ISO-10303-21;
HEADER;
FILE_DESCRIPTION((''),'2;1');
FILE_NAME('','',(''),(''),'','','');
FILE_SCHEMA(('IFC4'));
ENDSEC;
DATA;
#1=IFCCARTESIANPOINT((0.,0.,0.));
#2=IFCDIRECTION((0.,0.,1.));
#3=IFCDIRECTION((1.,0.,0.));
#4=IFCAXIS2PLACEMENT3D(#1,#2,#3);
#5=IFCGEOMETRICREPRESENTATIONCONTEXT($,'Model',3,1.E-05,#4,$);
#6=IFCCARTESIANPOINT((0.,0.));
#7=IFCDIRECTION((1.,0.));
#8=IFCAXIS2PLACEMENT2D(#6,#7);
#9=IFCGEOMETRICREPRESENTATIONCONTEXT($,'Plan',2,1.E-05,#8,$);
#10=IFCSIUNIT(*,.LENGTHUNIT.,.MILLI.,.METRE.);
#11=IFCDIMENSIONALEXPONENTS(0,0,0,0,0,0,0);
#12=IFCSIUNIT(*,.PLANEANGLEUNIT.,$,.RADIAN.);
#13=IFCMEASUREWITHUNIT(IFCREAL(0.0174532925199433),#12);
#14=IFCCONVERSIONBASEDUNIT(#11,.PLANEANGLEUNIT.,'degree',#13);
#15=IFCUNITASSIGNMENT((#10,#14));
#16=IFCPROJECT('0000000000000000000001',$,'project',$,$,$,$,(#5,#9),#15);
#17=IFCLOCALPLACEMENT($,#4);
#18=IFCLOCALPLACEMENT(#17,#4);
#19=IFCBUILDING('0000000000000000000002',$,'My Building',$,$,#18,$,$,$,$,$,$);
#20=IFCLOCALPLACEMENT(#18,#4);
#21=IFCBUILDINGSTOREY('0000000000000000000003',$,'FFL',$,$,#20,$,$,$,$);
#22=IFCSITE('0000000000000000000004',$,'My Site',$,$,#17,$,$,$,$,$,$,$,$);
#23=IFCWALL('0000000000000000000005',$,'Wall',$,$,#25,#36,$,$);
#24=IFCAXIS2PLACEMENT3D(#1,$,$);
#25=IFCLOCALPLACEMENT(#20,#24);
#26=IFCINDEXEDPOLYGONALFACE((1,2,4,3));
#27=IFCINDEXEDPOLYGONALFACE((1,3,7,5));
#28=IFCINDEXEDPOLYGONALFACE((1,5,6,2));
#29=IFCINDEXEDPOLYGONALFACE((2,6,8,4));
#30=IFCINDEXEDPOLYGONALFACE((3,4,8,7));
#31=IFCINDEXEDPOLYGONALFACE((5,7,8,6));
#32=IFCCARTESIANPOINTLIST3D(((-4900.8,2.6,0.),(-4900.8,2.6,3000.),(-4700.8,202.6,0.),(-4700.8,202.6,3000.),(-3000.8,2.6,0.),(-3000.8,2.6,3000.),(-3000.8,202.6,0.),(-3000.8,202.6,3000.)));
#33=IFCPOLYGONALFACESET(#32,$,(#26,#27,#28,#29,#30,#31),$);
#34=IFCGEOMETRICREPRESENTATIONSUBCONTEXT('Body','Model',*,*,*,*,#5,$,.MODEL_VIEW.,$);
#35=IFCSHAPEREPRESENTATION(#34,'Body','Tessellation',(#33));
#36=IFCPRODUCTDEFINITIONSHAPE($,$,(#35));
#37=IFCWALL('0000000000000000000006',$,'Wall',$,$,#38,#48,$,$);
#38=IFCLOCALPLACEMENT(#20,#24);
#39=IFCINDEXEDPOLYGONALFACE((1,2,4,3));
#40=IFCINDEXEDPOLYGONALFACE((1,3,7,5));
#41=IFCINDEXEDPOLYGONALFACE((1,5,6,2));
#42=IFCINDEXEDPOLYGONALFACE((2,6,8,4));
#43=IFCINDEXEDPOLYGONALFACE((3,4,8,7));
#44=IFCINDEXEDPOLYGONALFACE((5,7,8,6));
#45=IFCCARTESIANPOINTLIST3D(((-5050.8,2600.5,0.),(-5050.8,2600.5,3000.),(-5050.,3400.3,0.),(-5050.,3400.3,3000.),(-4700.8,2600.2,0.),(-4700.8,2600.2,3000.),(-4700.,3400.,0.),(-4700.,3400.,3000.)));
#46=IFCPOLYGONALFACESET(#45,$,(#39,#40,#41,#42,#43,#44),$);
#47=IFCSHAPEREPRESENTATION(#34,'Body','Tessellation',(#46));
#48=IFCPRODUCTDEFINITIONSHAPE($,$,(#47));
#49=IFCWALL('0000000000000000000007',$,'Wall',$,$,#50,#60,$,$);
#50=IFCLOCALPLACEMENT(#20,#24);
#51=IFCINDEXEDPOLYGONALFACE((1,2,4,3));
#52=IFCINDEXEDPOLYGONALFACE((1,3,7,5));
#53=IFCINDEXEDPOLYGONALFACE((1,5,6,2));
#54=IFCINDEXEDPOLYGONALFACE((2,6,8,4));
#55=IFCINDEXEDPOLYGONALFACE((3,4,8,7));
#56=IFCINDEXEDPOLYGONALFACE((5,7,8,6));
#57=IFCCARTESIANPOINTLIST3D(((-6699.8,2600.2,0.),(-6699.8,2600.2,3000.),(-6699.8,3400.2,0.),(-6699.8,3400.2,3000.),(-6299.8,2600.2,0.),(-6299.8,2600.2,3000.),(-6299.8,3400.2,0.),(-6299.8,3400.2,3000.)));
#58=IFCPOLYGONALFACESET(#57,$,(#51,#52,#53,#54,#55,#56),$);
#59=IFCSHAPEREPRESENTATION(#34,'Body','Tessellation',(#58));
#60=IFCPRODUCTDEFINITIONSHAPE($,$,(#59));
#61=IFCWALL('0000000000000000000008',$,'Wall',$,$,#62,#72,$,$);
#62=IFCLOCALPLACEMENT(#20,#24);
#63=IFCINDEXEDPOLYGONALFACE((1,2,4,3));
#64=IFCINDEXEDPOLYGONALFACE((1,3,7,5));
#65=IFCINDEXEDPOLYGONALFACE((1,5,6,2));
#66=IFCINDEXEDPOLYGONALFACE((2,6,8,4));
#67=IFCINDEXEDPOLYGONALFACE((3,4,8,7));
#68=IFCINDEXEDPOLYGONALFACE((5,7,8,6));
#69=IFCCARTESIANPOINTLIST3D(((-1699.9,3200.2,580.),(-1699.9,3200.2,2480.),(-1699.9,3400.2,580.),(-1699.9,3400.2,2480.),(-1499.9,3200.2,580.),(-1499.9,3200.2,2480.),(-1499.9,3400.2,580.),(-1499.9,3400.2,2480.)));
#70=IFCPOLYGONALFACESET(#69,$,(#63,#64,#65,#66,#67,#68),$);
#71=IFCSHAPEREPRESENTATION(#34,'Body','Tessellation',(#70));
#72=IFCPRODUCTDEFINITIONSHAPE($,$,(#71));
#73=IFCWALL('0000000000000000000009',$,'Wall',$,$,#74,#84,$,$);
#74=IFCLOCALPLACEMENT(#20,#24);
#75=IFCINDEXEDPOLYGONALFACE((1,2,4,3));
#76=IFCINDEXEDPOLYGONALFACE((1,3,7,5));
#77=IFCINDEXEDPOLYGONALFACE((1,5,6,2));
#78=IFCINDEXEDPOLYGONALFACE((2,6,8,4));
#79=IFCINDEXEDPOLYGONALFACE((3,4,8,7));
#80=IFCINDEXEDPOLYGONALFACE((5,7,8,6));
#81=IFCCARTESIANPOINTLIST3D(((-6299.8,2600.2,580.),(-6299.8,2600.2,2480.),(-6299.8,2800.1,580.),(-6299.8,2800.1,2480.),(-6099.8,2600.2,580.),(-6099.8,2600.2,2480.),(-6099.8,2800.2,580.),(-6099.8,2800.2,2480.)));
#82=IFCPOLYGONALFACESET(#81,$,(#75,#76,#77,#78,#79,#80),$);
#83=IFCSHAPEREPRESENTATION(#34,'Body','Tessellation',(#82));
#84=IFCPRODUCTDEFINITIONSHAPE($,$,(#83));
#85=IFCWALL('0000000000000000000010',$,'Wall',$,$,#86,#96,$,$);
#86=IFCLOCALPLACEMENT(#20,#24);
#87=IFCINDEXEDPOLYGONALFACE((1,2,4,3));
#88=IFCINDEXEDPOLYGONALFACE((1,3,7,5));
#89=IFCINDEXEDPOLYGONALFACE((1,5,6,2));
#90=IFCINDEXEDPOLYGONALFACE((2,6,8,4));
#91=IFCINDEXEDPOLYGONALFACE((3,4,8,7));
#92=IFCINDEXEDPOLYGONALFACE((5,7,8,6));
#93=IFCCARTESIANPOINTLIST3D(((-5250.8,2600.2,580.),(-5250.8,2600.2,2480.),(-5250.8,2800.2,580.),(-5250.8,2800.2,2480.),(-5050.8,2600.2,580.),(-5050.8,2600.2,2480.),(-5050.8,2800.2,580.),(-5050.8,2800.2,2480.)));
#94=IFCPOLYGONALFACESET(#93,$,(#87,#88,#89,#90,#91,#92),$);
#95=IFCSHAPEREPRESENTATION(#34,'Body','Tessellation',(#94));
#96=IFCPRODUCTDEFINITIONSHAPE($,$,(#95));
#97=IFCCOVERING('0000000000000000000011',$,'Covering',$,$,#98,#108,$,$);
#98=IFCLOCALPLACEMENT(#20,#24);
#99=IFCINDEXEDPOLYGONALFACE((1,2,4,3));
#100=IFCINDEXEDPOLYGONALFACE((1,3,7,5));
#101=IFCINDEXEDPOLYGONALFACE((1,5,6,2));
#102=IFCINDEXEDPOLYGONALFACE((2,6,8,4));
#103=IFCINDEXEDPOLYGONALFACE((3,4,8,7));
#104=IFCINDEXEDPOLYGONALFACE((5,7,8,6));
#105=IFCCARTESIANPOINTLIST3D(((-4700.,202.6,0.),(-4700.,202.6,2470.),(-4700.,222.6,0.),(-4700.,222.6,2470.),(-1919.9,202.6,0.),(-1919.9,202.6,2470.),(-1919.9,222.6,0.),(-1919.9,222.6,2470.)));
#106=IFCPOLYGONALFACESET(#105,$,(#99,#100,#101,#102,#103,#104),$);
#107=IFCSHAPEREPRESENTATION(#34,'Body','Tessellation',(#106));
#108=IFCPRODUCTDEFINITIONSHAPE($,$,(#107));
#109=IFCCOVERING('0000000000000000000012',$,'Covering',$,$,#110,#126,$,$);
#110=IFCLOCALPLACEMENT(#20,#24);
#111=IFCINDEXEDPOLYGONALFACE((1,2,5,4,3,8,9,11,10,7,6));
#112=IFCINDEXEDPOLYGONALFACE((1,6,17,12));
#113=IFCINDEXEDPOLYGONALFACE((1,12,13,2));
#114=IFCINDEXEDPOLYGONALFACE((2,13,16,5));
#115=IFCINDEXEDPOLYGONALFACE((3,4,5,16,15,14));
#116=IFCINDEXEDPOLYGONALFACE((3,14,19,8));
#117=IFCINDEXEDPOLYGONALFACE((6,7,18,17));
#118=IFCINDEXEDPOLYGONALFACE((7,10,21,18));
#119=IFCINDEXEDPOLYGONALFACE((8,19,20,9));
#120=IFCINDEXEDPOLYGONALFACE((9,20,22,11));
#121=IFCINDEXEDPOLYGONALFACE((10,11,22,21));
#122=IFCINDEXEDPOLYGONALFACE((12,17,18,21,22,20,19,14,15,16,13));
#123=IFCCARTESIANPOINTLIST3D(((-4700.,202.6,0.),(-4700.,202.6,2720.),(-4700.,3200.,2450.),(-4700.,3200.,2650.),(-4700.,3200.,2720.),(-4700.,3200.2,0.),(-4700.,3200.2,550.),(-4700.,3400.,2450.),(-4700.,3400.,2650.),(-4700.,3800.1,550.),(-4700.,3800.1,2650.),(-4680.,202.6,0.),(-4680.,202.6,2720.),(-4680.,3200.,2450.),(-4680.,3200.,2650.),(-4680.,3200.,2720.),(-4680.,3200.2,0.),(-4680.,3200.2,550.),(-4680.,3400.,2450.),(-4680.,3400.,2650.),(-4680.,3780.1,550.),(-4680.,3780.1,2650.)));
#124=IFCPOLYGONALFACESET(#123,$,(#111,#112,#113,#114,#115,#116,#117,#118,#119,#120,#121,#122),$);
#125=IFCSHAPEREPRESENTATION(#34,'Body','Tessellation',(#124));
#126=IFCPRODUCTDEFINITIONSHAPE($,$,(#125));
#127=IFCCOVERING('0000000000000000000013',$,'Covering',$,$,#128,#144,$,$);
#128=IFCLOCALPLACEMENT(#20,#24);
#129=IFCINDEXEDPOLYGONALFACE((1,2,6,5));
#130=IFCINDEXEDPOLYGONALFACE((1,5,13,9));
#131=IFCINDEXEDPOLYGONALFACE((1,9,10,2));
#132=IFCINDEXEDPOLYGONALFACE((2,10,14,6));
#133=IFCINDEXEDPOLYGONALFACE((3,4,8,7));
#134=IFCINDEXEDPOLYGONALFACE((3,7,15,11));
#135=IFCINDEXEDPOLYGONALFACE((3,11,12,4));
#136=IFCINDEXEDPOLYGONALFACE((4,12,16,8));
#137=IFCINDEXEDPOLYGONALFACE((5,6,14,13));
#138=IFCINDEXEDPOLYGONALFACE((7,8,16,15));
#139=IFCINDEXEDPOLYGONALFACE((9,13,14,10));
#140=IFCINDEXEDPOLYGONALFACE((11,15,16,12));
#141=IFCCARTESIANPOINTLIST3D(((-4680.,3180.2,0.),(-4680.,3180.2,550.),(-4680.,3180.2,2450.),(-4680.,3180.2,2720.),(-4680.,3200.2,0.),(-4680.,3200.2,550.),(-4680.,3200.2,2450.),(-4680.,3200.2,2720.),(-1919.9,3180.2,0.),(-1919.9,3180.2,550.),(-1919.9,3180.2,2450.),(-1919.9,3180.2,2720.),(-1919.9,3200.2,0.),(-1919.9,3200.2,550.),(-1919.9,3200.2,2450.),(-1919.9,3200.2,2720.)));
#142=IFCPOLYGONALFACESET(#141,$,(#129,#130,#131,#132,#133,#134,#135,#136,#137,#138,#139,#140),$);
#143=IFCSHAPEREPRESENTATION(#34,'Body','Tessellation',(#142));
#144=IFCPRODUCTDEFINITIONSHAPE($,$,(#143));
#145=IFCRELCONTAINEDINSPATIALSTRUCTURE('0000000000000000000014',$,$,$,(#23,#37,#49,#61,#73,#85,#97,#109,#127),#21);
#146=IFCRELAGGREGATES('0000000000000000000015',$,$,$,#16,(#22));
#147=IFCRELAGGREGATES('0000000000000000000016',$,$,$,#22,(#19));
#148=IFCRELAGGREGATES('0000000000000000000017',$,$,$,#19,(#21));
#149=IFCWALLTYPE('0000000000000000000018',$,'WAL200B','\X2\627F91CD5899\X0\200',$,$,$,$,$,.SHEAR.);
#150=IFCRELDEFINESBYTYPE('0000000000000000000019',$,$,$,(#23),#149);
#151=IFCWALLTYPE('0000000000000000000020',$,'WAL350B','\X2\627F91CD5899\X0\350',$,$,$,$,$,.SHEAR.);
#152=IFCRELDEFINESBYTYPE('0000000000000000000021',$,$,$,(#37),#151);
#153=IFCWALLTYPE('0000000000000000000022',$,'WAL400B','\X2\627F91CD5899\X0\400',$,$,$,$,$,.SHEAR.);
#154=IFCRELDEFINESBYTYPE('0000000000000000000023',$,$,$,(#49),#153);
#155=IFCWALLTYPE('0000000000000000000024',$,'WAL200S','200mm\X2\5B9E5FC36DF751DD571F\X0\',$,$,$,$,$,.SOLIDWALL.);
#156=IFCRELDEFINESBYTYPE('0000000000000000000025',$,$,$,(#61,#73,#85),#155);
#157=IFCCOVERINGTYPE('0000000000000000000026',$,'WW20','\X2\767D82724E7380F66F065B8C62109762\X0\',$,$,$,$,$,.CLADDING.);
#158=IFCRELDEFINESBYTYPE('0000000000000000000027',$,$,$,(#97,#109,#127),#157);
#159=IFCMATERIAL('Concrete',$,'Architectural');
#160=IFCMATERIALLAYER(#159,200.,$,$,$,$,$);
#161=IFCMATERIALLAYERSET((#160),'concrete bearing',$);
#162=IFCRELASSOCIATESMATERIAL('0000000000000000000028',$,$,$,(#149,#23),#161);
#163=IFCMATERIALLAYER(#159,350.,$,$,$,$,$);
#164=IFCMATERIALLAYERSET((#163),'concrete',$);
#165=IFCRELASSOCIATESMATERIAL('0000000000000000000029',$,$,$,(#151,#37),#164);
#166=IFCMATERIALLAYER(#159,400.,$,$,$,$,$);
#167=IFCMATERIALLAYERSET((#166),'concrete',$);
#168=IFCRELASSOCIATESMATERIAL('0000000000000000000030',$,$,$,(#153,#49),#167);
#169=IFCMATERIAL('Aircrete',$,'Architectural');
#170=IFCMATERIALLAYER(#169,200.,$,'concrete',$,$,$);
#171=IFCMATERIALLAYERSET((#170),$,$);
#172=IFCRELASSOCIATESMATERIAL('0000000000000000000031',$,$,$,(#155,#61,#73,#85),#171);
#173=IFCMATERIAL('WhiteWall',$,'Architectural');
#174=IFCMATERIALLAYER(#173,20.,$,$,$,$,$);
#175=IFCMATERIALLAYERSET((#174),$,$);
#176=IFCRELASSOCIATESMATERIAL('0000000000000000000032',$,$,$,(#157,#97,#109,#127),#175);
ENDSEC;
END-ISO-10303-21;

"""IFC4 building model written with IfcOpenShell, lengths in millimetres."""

from ifc_helpers import new_model, entity, si_unit, converted_unit, frame, origin_with_axes, origin_2d_with_axis, place, context, subcontext, project, spatial, line, indexed_curve, outline, extrude, material, layer, layer_set, layer_usage, type_object, element, save


model = new_model("IFC4")

# Units and contexts
model_context = context("Model", 3, precision=1e-05, world=origin_with_axes())
plan_context = context("Plan", 2, precision=1e-05, world=origin_2d_with_axis())
body_context_1 = subcontext(model_context, "Body", "Model", "MODEL_VIEW")
ifc_project = project(units=[si_unit("LENGTHUNIT", "METRE", prefix="MILLI"), converted_unit("PLANEANGLEUNIT", "degree", entity("IfcReal", 0.0174532925199433), si_unit("PLANEANGLEUNIT", "RADIAN"), dimensions=[0, 0, 0, 0, 0, 0, 0])], contexts=[model_context, plan_context])

# Site, building, storey
site_placement = place(None, origin_with_axes())
site = spatial("IfcSite", under=ifc_project, at=site_placement, Name="My Site")
building_placement = place(site_placement, origin_with_axes())
building = spatial("IfcBuilding", under=site, at=building_placement, Name="My Building")
storey_placement = place(building_placement, origin_with_axes())
storey = spatial("IfcBuildingStorey", under=building, at=storey_placement, Name="FFL")

# Shared definitions
ifc_material_1 = material(Name="Aircrete", Category="Architectural")

# Walls
ifc_material_2 = material(Name="Concrete", Category="Architectural")
ifc_layer_1 = layer(ifc_material_2, 200.0)
ifc_layer_set_1 = layer_set([ifc_layer_1], Name="concrete bearing")
wall_type_1 = type_object("IfcWallType", Name="WAL200B", Description="承重墙200", PredefinedType="SHEAR", material=ifc_layer_set_1)
ifc_layer_usage_1 = layer_usage(ifc_layer_set_1, "AXIS2", "NEGATIVE", 0.0)
wall_1_placement = place(storey_placement, frame((-4700.8, 202.6, 0.0), z_axis=(0.0, 0.0, 1.0), x_axis=(1.0, 0.000001, 0.0)))
element("IfcWall", 1, at=wall_1_placement, inside=storey, type_object=wall_type_1, material=ifc_layer_usage_1, Name="Wall", context=body_context_1, shape_type="SweptSolid", body=[
    extrude(outline(indexed_curve([(-200.0, -200.0), (0.0, 0.0), (1700.0, 0.0), (1700.0, -200.0)], segments=[line(1, 2, 3, 4, 1)])), origin_with_axes(), (0.0, 0.0, 1.0), 3000.0),
])
ifc_layer_2 = layer(ifc_material_2, 350.0)
ifc_layer_set_2 = layer_set([ifc_layer_2], Name="concrete")
ifc_layer_usage_2 = layer_usage(ifc_layer_set_2, "AXIS2", "POSITIVE", 0.0)
wall_type_2 = type_object("IfcWallType", Name="WAL350B", Description="承重墙350", PredefinedType="SHEAR", material=ifc_layer_set_2)
wall_2_placement = place(storey_placement, frame((-4700.8, 2600.2, 0.0), z_axis=(0.0, 0.0, 1.0), x_axis=(0.000938, 1.0, 0.0)))
element("IfcWall", 2, at=wall_2_placement, inside=storey, type_object=wall_type_2, material=ifc_layer_usage_2, Name="Wall", context=body_context_1, shape_type="SweptSolid", body=[
    extrude(outline(indexed_curve([(0.0, 0.0), (0.0, 350.0), (799.8, 350.0), (799.8, 0.0)], segments=[line(1, 2, 3, 4, 1)])), origin_with_axes(), (0.0, 0.0, 1.0), 3000.0),
])
ifc_layer_3 = layer(ifc_material_2, 400.0)
ifc_layer_set_3 = layer_set([ifc_layer_3], Name="concrete")
ifc_layer_usage_3 = layer_usage(ifc_layer_set_3, "AXIS2", "POSITIVE", 0.0)
wall_type_3 = type_object("IfcWallType", Name="WAL400B", Description="承重墙400", PredefinedType="SHEAR", material=ifc_layer_set_3)
wall_3_placement = place(storey_placement, frame((-6699.8, 3400.2, 0.0), z_axis=(0.0, 0.0, 1.0), x_axis=(0.0, -1.0, 0.0)))
element("IfcWall", 3, at=wall_3_placement, inside=storey, type_object=wall_type_3, material=ifc_layer_usage_3, Name="Wall", context=body_context_1, shape_type="SweptSolid", body=[
    extrude(outline(indexed_curve([(0.0, 0.0), (0.0, 400.0), (800.0, 400.0), (800.0, 0.0)], segments=[line(1, 2, 3, 4, 1)])), origin_with_axes(), (0.0, 0.0, 1.0), 3000.0),
])
ifc_layer_4 = layer(ifc_material_1, 200.0, Name="concrete")
ifc_layer_set_4 = layer_set([ifc_layer_4])
ifc_layer_usage_4 = layer_usage(ifc_layer_set_4, "AXIS2", "NEGATIVE", 0.0)
wall_type_4 = type_object("IfcWallType", Name="WAL200S", Description="200mm实心混凝土", PredefinedType="SOLIDWALL", material=ifc_layer_set_4)
wall_4_placement = place(storey_placement, frame((-1699.9, 3200.2, 580.0), z_axis=(0.0, 0.0, 1.0), x_axis=(-0.000002, 1.0, 0.0)))
element("IfcWall", 4, at=wall_4_placement, inside=storey, type_object=wall_type_4, material=ifc_layer_usage_4, Name="Wall", context=body_context_1, shape_type="SweptSolid", body=[
    extrude(outline(indexed_curve([(0.0, -200.0), (0.0, 0.0), (200.0, 0.0), (200.0, -200.0)], segments=[line(1, 2, 3, 4, 1)])), origin_with_axes(), (0.0, 0.0, 1.0), 1900.0),
])
ifc_layer_usage_5 = layer_usage(ifc_layer_set_4, "AXIS2", "NEGATIVE", 0.0)
wall_5_placement = place(storey_placement, frame((-6299.8, 2600.2, 580.0), z_axis=(0.0, 0.0, 1.0), x_axis=(-0.000002, 1.0, 0.0)))
element("IfcWall", 5, at=wall_5_placement, inside=storey, type_object=wall_type_4, material=ifc_layer_usage_5, Name="Wall", context=body_context_1, shape_type="SweptSolid", body=[
    extrude(outline(indexed_curve([(0.0, -200.0), (0.0, 0.0), (200.0, 0.0), (200.0, -200.0)], segments=[line(1, 2, 3, 4, 1)])), origin_with_axes(), (0.0, 0.0, 1.0), 1900.0),
])
ifc_layer_usage_6 = layer_usage(ifc_layer_set_4, "AXIS2", "NEGATIVE", 0.0)
wall_6_placement = place(storey_placement, frame((-5050.8, 2800.2, 580.0), z_axis=(0.0, 0.0, 1.0), x_axis=(0.000002, -1.0, 0.0)))
element("IfcWall", 6, at=wall_6_placement, inside=storey, type_object=wall_type_4, material=ifc_layer_usage_6, Name="Wall", context=body_context_1, shape_type="SweptSolid", body=[
    extrude(outline(indexed_curve([(0.0, -200.0), (0.0, 0.0), (200.0, 0.0), (200.0, -200.0)], segments=[line(1, 2, 3, 4, 1)])), origin_with_axes(), (0.0, 0.0, 1.0), 1900.0),
])

# Covering
ifc_material_3 = material(Name="WhiteWall", Category="Architectural")
ifc_layer_5 = layer(ifc_material_3, 20.0)
ifc_layer_set_5 = layer_set([ifc_layer_5])
ifc_layer_usage_7 = layer_usage(ifc_layer_set_5, "AXIS2", "POSITIVE", 0.0)
covering_type = type_object("IfcCoveringType", Name="WW20", Description="白色乳胶漆完成面", PredefinedType="CLADDING", material=ifc_layer_set_5)
covering_1_placement = place(storey_placement, frame((-4700.0, 202.6, 0.0), z_axis=(0.0, 0.0, 1.0), x_axis=(1.0, -0.000001, 0.0)))
element("IfcCovering", 7, at=covering_1_placement, inside=storey, type_object=covering_type, material=ifc_layer_usage_7, Name="Covering", context=body_context_1, shape_type="SweptSolid", body=[
    extrude(outline(indexed_curve([(0.0, 0.0), (0.0, 20.0), (2780.1, 20.0), (2780.1, 0.0)], segments=[line(1, 2, 3, 4, 1)])), origin_with_axes(), (0.0, 0.0, 1.0), 2470.0),
])

# Covering, openings
ifc_layer_usage_8 = layer_usage(ifc_layer_set_5, "AXIS2", "POSITIVE", 0.0)
covering_2_placement = place(storey_placement, frame((-4700.0, 3800.1, 0.0), z_axis=(0.0, 0.0, 1.0), x_axis=(-0.000001, -1.0, 0.0)))
covering_2 = element("IfcCovering", 8, at=covering_2_placement, inside=storey, type_object=covering_type, material=ifc_layer_usage_8, Name="Covering", context=body_context_1, shape_type="SweptSolid", body=[
    extrude(outline(indexed_curve([(0.0, 0.0), (20.0, 20.0), (3597.6, 20.0), (3597.6, 0.0)], segments=[line(1, 2, 3, 4, 1)])), origin_with_axes(), (0.0, 0.0, 1.0), 2720.0),
])
opening_1_placement = place(covering_2_placement, frame((0.0, 100.0, 0.0), z_axis=(0.000001, -1.0, 0.0), x_axis=(1.0, 0.000001, 0.0)))
element("IfcOpeningElement", 9, at=opening_1_placement, cuts=covering_2, PredefinedType="OPENING", context=body_context_1, shape_type="SweptSolid", body=[
    extrude(outline(indexed_curve([(0.0, 550.0), (600.0, 550.0), (600.0, 0.0), (0.0, 0.0), (0.0, 550.0)])), origin_with_axes(), (0.0, 0.0, 1.0), 500.0),
])
opening_2_placement = place(covering_2_placement, frame((0.0, 100.0, 2650.0), z_axis=(0.000001, -1.0, 0.0), x_axis=(1.0, 0.000001, 0.0)))
element("IfcOpeningElement", 10, at=opening_2_placement, cuts=covering_2, PredefinedType="OPENING", context=body_context_1, shape_type="SweptSolid", body=[
    extrude(outline(indexed_curve([(0.0, 0.0), (600.2, 0.0), (600.2, 550.0), (0.0, 550.0), (0.0, 0.0)])), origin_with_axes(), (0.0, 0.0, 1.0), 500.0),
])
opening_3_placement = place(covering_2_placement, frame((0.0, 100.0, 2450.0), z_axis=(0.000001, -1.0, 0.0), x_axis=(1.0, 0.000001, 0.0)))
element("IfcOpeningElement", 11, at=opening_3_placement, cuts=covering_2, PredefinedType="OPENING", context=body_context_1, shape_type="SweptSolid", body=[
    extrude(outline(indexed_curve([(400.2, 200.0), (600.2, 200.0), (600.2, 0.0), (400.2, 0.0), (400.2, 200.0)])), origin_with_axes(), (0.0, 0.0, 1.0), 500.0),
])

# Covering, opening
ifc_layer_usage_9 = layer_usage(ifc_layer_set_5, "AXIS2", "NEGATIVE", 0.0)
covering_3_placement = place(storey_placement, frame((-4700.0, 3200.2, 0.0), z_axis=(0.0, 0.0, 1.0), x_axis=(1.0, -0.000001, 0.0)))
covering_3 = element("IfcCovering", 12, at=covering_3_placement, inside=storey, type_object=covering_type, material=ifc_layer_usage_9, Name="Covering", context=body_context_1, shape_type="SweptSolid", body=[
    extrude(outline(indexed_curve([(20.0, -20.0), (20.0, 0.0), (2780.1, 0.0), (2780.1, -20.0)], segments=[line(1, 2, 3, 4, 1)])), origin_with_axes(), (0.0, 0.0, 1.0), 2720.0),
])
opening_4_placement = place(covering_3_placement, frame((20.0, 200.0, 550.0), z_axis=(0.000001, -1.0, 0.0), x_axis=(1.0, 0.000001, 0.0)))
element("IfcOpeningElement", 13, at=opening_4_placement, cuts=covering_3, PredefinedType="OPENING", context=body_context_1, shape_type="SweptSolid", body=[
    extrude(outline(indexed_curve([(0.0, 1900.0), (2760.1, 1900.0), (2760.1, 0.0), (0.0, 0.0), (0.0, 1900.0)])), origin_with_axes(), (0.0, 0.0, 1.0), 500.0),
])

save(model, "model.ifc")
